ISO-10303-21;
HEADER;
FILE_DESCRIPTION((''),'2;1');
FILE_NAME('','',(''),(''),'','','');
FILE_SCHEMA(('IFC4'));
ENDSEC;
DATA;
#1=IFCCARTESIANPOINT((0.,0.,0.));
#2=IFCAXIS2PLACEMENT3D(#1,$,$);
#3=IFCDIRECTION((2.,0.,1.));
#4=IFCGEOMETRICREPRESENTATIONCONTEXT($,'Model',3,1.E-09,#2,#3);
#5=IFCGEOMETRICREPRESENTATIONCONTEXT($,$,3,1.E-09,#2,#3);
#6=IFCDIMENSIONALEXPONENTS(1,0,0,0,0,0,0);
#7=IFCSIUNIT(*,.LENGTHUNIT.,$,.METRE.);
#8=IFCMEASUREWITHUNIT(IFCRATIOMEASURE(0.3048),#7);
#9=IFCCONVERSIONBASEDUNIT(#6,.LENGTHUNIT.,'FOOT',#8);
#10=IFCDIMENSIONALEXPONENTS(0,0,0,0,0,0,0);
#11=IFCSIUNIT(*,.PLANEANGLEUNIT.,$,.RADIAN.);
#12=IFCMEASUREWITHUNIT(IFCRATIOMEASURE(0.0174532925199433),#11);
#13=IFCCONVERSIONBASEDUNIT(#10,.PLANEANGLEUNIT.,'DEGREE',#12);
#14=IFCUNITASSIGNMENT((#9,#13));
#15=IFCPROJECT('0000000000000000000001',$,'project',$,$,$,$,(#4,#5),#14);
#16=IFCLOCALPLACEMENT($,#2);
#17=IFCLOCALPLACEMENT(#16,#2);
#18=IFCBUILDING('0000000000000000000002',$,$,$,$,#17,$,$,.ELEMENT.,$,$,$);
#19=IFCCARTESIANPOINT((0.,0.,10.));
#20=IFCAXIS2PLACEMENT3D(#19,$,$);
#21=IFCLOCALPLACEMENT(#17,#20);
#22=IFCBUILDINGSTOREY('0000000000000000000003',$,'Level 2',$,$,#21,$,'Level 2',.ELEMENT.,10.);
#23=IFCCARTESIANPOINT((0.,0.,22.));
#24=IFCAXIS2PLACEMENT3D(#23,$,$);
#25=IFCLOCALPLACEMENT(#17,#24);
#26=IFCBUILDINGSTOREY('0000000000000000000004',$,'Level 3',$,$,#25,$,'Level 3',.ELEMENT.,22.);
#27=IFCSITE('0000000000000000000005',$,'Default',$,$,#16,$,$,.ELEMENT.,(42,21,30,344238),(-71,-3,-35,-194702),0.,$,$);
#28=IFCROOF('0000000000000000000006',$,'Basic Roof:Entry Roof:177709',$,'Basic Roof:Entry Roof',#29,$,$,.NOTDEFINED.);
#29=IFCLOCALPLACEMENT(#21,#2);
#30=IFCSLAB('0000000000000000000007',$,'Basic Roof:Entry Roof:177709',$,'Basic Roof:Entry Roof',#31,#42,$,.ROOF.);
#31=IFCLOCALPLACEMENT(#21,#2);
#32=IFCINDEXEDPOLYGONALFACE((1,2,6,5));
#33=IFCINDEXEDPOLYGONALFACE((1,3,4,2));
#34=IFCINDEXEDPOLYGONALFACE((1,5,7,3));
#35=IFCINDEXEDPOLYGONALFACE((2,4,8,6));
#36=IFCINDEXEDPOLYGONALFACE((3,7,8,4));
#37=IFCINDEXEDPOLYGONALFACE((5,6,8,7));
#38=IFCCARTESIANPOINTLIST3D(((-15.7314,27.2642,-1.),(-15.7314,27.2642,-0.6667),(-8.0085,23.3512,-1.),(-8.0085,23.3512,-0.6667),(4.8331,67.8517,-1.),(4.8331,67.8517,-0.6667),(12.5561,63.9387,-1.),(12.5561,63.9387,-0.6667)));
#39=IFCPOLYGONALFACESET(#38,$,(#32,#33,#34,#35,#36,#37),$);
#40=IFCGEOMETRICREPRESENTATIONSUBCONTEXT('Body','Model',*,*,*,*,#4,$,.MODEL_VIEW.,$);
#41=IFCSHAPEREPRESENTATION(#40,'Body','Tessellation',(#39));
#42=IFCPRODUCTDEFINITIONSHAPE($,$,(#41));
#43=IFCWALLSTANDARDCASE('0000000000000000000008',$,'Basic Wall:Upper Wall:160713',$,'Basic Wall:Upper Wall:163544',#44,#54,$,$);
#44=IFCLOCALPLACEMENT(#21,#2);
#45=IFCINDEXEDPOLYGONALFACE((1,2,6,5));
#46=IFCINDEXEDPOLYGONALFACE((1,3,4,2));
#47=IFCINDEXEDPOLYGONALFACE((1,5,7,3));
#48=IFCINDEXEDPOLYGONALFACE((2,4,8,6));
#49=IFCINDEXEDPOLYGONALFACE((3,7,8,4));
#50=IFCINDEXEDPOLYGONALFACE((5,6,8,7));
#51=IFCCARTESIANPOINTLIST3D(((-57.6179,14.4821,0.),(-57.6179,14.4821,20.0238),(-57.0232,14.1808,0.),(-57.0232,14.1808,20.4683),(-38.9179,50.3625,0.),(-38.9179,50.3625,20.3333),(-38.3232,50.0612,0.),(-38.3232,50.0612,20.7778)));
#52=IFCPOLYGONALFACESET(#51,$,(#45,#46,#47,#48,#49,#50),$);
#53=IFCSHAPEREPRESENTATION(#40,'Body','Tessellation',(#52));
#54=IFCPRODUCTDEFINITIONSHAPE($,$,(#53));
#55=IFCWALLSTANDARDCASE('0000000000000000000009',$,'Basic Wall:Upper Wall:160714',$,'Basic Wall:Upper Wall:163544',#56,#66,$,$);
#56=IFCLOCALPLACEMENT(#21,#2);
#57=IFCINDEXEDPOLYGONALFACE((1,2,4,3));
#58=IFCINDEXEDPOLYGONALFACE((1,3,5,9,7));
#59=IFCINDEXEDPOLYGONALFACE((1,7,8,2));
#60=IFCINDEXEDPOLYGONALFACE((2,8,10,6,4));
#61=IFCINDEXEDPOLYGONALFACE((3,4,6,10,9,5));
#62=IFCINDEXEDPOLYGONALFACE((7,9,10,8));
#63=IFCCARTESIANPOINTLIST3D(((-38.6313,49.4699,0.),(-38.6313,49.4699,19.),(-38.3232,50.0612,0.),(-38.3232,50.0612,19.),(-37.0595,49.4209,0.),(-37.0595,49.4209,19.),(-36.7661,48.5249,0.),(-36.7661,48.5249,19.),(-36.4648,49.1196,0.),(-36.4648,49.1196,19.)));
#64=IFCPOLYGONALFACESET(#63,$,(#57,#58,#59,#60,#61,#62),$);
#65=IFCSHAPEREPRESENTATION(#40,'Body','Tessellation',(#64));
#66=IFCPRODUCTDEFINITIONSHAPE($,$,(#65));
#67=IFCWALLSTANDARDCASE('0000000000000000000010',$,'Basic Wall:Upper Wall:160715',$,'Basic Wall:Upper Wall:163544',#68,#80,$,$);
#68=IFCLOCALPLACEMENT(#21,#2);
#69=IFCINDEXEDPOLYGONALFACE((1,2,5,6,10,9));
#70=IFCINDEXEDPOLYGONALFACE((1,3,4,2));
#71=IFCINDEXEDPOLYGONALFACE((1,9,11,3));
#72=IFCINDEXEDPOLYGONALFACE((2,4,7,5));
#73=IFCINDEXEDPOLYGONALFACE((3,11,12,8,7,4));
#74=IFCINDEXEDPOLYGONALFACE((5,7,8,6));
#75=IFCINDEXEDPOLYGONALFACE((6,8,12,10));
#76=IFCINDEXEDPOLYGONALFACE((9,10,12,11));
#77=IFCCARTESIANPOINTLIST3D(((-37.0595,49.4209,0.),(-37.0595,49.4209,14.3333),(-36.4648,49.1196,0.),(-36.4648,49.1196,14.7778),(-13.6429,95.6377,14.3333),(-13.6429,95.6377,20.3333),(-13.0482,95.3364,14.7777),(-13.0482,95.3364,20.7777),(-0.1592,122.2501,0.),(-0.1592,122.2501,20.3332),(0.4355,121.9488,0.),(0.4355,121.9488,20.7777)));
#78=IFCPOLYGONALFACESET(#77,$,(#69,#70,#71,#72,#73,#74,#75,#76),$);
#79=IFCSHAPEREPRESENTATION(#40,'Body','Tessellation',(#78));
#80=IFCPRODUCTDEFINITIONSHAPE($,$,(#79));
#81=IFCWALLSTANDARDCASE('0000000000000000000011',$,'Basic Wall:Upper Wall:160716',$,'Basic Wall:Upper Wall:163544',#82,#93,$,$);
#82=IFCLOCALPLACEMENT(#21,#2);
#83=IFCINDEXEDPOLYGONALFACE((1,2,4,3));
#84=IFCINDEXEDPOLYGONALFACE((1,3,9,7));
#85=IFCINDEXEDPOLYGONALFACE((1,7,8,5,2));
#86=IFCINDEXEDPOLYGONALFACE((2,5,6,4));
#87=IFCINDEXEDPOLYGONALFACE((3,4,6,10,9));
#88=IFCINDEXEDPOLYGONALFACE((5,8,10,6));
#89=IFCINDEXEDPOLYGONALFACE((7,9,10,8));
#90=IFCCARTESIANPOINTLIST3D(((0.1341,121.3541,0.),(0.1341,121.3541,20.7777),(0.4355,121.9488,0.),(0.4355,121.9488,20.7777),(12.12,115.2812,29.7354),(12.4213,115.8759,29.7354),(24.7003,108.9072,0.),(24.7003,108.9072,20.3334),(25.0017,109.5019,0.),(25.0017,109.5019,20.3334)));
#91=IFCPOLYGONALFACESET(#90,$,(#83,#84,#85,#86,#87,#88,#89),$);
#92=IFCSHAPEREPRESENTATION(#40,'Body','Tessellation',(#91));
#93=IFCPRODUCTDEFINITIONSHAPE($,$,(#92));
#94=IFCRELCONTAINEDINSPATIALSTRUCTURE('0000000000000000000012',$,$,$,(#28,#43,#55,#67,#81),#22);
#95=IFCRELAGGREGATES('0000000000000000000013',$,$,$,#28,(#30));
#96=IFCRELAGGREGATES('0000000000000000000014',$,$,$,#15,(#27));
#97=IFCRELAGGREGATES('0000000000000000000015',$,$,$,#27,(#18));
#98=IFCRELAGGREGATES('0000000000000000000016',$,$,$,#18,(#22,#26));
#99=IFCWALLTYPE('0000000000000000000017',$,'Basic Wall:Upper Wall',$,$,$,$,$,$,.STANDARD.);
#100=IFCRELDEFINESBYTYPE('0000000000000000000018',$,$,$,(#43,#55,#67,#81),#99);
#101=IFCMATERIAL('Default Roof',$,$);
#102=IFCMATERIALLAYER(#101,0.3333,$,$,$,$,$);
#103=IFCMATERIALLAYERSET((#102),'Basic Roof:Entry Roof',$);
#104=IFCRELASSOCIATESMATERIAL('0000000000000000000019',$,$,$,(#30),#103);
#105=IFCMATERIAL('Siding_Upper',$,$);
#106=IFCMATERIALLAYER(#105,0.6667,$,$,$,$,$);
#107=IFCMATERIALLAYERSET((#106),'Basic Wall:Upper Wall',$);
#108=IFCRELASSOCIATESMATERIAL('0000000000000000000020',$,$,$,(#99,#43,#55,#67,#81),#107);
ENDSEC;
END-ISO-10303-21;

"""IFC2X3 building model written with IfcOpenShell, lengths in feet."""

from ifc_helpers import new_model, entity, si_unit, converted_unit, direction, frame, frame_2d, origin, place, context, subcontext, project, spatial, polyline, rectangle, outline, extrude, clip, bounded_halfspace, material, layer, layer_set, layer_usage, type_object, element, aggregate, save


model = new_model("IFC2X3")

# Units and contexts
model_context = context("Model", 3, precision=1e-09, world=origin(), true_north=direction((2.0, 0.0, 1.0)))
context_of_model = context(None, 3, precision=1e-09, world=origin(), true_north=direction((2.0, 0.0, 1.0)))
body_context = subcontext(model_context, "Body", "Model", "MODEL_VIEW")
ifc_project = project(units=[converted_unit("LENGTHUNIT", "FOOT", entity("IfcRatioMeasure", 0.3048), si_unit("LENGTHUNIT", "METRE"), dimensions=[1, 0, 0, 0, 0, 0, 0]), converted_unit("PLANEANGLEUNIT", "DEGREE", entity("IfcRatioMeasure", 0.0174532925199433), si_unit("PLANEANGLEUNIT", "RADIAN"), dimensions=[0, 0, 0, 0, 0, 0, 0])], contexts=[model_context, context_of_model])

# Site, building, storey
site_placement = place(None, origin())
site = spatial("IfcSite", under=ifc_project, at=site_placement, Name="Default", CompositionType="ELEMENT", RefLatitude=(42, 21, 30, 344238), RefLongitude=(-71, -3, -35, -194702), RefElevation=0.0)
building_placement = place(site_placement, origin())
building = spatial("IfcBuilding", under=site, at=building_placement, CompositionType="ELEMENT")
storey_1_placement = place(building_placement, frame((0.0, 0.0, 10.0)))
storey_1 = spatial("IfcBuildingStorey", under=building, at=storey_1_placement, Name="Level 2", LongName="Level 2", CompositionType="ELEMENT", Elevation=10.0)

# Roof, slab
ifc_material_1 = material(Name="Default Roof")
ifc_layer_1 = layer(ifc_material_1, 0.3333)
ifc_layer_set_1 = layer_set([ifc_layer_1], Name="Basic Roof:Entry Roof")
roof_1_placement = place(storey_1_placement, frame((-15.7314, 23.3512, -1.0)))
roof_1 = element("IfcRoof", 1, at=roof_1_placement, inside=storey_1, Name="Basic Roof:Entry Roof:177709", ObjectType="Basic Roof:Entry Roof", ShapeType="NOTDEFINED")
slab_1_placement = place(roof_1_placement, origin())
slab_1 = element("IfcSlab", 2, at=slab_1_placement, material=ifc_layer_set_1, Name="Basic Roof:Entry Roof:177709", ObjectType="Basic Roof:Entry Roof", PredefinedType="ROOF", context=body_context, shape_type="SweptSolid", body=[
    extrude(rectangle(XDim=45.5, YDim=8.6577, at=frame_2d((0.0, 0.0), x_axis=(0.451968, 0.892034))), frame((14.1437, 22.2503, 0.0)), (0.0, 0.0, 1.0), 0.3333),
])
aggregate(roof_1, [slab_1])

# Walls
ifc_material_2 = material(Name="Siding_Upper")
ifc_layer_2 = layer(ifc_material_2, 0.6667)
ifc_layer_set_2 = layer_set([ifc_layer_2], Name="Basic Wall:Upper Wall")
ifc_layer_usage_1 = layer_usage(ifc_layer_set_2, "AXIS2", "NEGATIVE", 0.3333)
wall_type = type_object("IfcWallType", Name="Basic Wall:Upper Wall", PredefinedType="STANDARD", material=ifc_layer_set_2)
wall_1_placement = place(storey_1_placement, frame((-57.3223, 14.328, 0.0), z_axis=(0.0, 0.0, 1.0), x_axis=(0.462173, 0.88679, 0.0)))
element("IfcWallStandardCase", 3, at=wall_1_placement, inside=storey_1, type_object=wall_type, material=ifc_layer_usage_1, Name="Basic Wall:Upper Wall:160713", ObjectType="Basic Wall:Upper Wall:163544", context=body_context, shape_type="Clipping", body=[
    clip(extrude(outline(polyline([(40.4686, -0.3333), (40.461, 0.3333), (0.0, 0.3333), (0.0077, -0.3333), (0.6744, -0.3333), (39.8019, -0.3333), (40.4686, -0.3333)])), origin(), (0.0, 0.0, 1.0), 20.7778), bounded_halfspace(frame((0.0077, -0.3333, 20.4683), z_axis=(-0.006365, 0.554664, 0.83205), x_axis=(-0.999934, -0.011474, 0.0)), False, frame((0.0077, -0.3333, 20.4683)), polyline([(0.0, 0.0), (0.6667, 0.0), (40.461, 0.0), (40.4533, 0.6667), (-0.0077, 0.6667), (0.0, 0.0)]))),
])
ifc_layer_usage_2 = layer_usage(ifc_layer_set_2, "AXIS2", "NEGATIVE", 0.3333)
wall_2_placement = place(storey_1_placement, frame((-38.4807, 49.7673, 0.0), z_axis=(0.0, 0.0, 1.0), x_axis=(0.892035, -0.451966, 0.0)))
element("IfcWallStandardCase", 4, at=wall_2_placement, inside=storey_1, type_object=wall_type, material=ifc_layer_usage_2, Name="Basic Wall:Upper Wall:160714", ObjectType="Basic Wall:Upper Wall:163544", context=body_context, shape_type="SweptSolid", body=[
    extrude(outline(polyline([(2.0909, -0.3333), (2.0909, 0.3333), (1.4243, 0.3333), (0.0077, 0.3333), (0.0, -0.3333), (2.0909, -0.3333)])), origin(), (0.0, 0.0, 1.0), 19.0),
])
ifc_layer_usage_3 = layer_usage(ifc_layer_set_2, "AXIS2", "NEGATIVE", 0.3333)
wall_3_placement = place(storey_1_placement, frame((-36.7621, 49.2702, 0.0), z_axis=(0.0, 0.0, 1.0), x_axis=(0.451966, 0.892035, 0.0)))
element("IfcWallStandardCase", 5, at=wall_3_placement, inside=storey_1, type_object=wall_type, material=ifc_layer_usage_3, Name="Basic Wall:Upper Wall:160715", ObjectType="Basic Wall:Upper Wall:163544", context=body_context, shape_type="Clipping", body=[
    clip(clip(extrude(rectangle(XDim=81.6439, YDim=0.6667, at=frame_2d((40.8219, 0.0), x_axis=(-1.0, 0.0))), origin(), (0.0, 0.0, 1.0), 20.7777), bounded_halfspace(frame((0.0, -0.3333, 14.7778), z_axis=(0.000001, 0.5547, 0.83205), x_axis=(-1.0, 0.000002, 0.0)), False, frame((0.0, -0.3333, 14.7778)), polyline([(0.0, 0.0), (51.8105, 0.0), (51.8105, 0.6667), (0.0, 0.6667), (0.0, 0.0)]))), bounded_halfspace(frame((51.8105, -0.3333, 20.7777), z_axis=(0.000001, 0.5547, 0.83205), x_axis=(-1.0, 0.000002, 0.0)), False, frame((51.8105, -0.3333, 20.7777)), polyline([(0.0, 0.0), (29.1667, 0.0), (29.8333, 0.0), (29.8333, 0.6667), (0.0, 0.6667), (0.0, 0.0)]))),
])
ifc_layer_usage_4 = layer_usage(ifc_layer_set_2, "AXIS2", "NEGATIVE", 0.3333)
wall_4_placement = place(storey_1_placement, frame((0.2848, 121.6514, 0.0), z_axis=(0.0, 0.0, 1.0), x_axis=(0.892035, -0.451966, 0.0)))
element("IfcWallStandardCase", 6, at=wall_4_placement, inside=storey_1, type_object=wall_type, material=ifc_layer_usage_4, Name="Basic Wall:Upper Wall:160716", ObjectType="Basic Wall:Upper Wall:163544", context=body_context, shape_type="Clipping", body=[
    clip(clip(extrude(rectangle(XDim=27.5395, YDim=0.6667, at=frame_2d((13.7697, 0.0), x_axis=(-1.0, 0.0))), origin(), (0.0, 0.0, 1.0), 29.7354), bounded_halfspace(frame((0.0, -0.3333, 20.7777), z_axis=(-0.5547, 0.000001, 0.83205), x_axis=(-0.000002, -1.0, 0.0)), False, frame((0.0, -0.3333, 20.7777)), polyline([(0.0, 0.0), (13.4365, 0.0), (13.4365, 0.6667), (0.0, 0.6667), (0.0, 0.0)]))), bounded_halfspace(frame((13.4365, -0.3333, 29.7354), z_axis=(0.5547, -0.000001, 0.83205), x_axis=(0.000002, 1.0, 0.0)), False, frame((13.4365, -0.3333, 29.7354)), polyline([(0.0, 0.0), (13.4363, 0.0), (14.103, 0.0), (14.103, 0.6667), (0.0, 0.6667), (0.0, 0.0)]))),
])

# Shared definitions
storey_2_placement = place(building_placement, frame((0.0, 0.0, 22.0)))
storey_2 = spatial("IfcBuildingStorey", under=building, at=storey_2_placement, Name="Level 3", LongName="Level 3", CompositionType="ELEMENT", Elevation=22.0)

save(model, "model.ifc")
